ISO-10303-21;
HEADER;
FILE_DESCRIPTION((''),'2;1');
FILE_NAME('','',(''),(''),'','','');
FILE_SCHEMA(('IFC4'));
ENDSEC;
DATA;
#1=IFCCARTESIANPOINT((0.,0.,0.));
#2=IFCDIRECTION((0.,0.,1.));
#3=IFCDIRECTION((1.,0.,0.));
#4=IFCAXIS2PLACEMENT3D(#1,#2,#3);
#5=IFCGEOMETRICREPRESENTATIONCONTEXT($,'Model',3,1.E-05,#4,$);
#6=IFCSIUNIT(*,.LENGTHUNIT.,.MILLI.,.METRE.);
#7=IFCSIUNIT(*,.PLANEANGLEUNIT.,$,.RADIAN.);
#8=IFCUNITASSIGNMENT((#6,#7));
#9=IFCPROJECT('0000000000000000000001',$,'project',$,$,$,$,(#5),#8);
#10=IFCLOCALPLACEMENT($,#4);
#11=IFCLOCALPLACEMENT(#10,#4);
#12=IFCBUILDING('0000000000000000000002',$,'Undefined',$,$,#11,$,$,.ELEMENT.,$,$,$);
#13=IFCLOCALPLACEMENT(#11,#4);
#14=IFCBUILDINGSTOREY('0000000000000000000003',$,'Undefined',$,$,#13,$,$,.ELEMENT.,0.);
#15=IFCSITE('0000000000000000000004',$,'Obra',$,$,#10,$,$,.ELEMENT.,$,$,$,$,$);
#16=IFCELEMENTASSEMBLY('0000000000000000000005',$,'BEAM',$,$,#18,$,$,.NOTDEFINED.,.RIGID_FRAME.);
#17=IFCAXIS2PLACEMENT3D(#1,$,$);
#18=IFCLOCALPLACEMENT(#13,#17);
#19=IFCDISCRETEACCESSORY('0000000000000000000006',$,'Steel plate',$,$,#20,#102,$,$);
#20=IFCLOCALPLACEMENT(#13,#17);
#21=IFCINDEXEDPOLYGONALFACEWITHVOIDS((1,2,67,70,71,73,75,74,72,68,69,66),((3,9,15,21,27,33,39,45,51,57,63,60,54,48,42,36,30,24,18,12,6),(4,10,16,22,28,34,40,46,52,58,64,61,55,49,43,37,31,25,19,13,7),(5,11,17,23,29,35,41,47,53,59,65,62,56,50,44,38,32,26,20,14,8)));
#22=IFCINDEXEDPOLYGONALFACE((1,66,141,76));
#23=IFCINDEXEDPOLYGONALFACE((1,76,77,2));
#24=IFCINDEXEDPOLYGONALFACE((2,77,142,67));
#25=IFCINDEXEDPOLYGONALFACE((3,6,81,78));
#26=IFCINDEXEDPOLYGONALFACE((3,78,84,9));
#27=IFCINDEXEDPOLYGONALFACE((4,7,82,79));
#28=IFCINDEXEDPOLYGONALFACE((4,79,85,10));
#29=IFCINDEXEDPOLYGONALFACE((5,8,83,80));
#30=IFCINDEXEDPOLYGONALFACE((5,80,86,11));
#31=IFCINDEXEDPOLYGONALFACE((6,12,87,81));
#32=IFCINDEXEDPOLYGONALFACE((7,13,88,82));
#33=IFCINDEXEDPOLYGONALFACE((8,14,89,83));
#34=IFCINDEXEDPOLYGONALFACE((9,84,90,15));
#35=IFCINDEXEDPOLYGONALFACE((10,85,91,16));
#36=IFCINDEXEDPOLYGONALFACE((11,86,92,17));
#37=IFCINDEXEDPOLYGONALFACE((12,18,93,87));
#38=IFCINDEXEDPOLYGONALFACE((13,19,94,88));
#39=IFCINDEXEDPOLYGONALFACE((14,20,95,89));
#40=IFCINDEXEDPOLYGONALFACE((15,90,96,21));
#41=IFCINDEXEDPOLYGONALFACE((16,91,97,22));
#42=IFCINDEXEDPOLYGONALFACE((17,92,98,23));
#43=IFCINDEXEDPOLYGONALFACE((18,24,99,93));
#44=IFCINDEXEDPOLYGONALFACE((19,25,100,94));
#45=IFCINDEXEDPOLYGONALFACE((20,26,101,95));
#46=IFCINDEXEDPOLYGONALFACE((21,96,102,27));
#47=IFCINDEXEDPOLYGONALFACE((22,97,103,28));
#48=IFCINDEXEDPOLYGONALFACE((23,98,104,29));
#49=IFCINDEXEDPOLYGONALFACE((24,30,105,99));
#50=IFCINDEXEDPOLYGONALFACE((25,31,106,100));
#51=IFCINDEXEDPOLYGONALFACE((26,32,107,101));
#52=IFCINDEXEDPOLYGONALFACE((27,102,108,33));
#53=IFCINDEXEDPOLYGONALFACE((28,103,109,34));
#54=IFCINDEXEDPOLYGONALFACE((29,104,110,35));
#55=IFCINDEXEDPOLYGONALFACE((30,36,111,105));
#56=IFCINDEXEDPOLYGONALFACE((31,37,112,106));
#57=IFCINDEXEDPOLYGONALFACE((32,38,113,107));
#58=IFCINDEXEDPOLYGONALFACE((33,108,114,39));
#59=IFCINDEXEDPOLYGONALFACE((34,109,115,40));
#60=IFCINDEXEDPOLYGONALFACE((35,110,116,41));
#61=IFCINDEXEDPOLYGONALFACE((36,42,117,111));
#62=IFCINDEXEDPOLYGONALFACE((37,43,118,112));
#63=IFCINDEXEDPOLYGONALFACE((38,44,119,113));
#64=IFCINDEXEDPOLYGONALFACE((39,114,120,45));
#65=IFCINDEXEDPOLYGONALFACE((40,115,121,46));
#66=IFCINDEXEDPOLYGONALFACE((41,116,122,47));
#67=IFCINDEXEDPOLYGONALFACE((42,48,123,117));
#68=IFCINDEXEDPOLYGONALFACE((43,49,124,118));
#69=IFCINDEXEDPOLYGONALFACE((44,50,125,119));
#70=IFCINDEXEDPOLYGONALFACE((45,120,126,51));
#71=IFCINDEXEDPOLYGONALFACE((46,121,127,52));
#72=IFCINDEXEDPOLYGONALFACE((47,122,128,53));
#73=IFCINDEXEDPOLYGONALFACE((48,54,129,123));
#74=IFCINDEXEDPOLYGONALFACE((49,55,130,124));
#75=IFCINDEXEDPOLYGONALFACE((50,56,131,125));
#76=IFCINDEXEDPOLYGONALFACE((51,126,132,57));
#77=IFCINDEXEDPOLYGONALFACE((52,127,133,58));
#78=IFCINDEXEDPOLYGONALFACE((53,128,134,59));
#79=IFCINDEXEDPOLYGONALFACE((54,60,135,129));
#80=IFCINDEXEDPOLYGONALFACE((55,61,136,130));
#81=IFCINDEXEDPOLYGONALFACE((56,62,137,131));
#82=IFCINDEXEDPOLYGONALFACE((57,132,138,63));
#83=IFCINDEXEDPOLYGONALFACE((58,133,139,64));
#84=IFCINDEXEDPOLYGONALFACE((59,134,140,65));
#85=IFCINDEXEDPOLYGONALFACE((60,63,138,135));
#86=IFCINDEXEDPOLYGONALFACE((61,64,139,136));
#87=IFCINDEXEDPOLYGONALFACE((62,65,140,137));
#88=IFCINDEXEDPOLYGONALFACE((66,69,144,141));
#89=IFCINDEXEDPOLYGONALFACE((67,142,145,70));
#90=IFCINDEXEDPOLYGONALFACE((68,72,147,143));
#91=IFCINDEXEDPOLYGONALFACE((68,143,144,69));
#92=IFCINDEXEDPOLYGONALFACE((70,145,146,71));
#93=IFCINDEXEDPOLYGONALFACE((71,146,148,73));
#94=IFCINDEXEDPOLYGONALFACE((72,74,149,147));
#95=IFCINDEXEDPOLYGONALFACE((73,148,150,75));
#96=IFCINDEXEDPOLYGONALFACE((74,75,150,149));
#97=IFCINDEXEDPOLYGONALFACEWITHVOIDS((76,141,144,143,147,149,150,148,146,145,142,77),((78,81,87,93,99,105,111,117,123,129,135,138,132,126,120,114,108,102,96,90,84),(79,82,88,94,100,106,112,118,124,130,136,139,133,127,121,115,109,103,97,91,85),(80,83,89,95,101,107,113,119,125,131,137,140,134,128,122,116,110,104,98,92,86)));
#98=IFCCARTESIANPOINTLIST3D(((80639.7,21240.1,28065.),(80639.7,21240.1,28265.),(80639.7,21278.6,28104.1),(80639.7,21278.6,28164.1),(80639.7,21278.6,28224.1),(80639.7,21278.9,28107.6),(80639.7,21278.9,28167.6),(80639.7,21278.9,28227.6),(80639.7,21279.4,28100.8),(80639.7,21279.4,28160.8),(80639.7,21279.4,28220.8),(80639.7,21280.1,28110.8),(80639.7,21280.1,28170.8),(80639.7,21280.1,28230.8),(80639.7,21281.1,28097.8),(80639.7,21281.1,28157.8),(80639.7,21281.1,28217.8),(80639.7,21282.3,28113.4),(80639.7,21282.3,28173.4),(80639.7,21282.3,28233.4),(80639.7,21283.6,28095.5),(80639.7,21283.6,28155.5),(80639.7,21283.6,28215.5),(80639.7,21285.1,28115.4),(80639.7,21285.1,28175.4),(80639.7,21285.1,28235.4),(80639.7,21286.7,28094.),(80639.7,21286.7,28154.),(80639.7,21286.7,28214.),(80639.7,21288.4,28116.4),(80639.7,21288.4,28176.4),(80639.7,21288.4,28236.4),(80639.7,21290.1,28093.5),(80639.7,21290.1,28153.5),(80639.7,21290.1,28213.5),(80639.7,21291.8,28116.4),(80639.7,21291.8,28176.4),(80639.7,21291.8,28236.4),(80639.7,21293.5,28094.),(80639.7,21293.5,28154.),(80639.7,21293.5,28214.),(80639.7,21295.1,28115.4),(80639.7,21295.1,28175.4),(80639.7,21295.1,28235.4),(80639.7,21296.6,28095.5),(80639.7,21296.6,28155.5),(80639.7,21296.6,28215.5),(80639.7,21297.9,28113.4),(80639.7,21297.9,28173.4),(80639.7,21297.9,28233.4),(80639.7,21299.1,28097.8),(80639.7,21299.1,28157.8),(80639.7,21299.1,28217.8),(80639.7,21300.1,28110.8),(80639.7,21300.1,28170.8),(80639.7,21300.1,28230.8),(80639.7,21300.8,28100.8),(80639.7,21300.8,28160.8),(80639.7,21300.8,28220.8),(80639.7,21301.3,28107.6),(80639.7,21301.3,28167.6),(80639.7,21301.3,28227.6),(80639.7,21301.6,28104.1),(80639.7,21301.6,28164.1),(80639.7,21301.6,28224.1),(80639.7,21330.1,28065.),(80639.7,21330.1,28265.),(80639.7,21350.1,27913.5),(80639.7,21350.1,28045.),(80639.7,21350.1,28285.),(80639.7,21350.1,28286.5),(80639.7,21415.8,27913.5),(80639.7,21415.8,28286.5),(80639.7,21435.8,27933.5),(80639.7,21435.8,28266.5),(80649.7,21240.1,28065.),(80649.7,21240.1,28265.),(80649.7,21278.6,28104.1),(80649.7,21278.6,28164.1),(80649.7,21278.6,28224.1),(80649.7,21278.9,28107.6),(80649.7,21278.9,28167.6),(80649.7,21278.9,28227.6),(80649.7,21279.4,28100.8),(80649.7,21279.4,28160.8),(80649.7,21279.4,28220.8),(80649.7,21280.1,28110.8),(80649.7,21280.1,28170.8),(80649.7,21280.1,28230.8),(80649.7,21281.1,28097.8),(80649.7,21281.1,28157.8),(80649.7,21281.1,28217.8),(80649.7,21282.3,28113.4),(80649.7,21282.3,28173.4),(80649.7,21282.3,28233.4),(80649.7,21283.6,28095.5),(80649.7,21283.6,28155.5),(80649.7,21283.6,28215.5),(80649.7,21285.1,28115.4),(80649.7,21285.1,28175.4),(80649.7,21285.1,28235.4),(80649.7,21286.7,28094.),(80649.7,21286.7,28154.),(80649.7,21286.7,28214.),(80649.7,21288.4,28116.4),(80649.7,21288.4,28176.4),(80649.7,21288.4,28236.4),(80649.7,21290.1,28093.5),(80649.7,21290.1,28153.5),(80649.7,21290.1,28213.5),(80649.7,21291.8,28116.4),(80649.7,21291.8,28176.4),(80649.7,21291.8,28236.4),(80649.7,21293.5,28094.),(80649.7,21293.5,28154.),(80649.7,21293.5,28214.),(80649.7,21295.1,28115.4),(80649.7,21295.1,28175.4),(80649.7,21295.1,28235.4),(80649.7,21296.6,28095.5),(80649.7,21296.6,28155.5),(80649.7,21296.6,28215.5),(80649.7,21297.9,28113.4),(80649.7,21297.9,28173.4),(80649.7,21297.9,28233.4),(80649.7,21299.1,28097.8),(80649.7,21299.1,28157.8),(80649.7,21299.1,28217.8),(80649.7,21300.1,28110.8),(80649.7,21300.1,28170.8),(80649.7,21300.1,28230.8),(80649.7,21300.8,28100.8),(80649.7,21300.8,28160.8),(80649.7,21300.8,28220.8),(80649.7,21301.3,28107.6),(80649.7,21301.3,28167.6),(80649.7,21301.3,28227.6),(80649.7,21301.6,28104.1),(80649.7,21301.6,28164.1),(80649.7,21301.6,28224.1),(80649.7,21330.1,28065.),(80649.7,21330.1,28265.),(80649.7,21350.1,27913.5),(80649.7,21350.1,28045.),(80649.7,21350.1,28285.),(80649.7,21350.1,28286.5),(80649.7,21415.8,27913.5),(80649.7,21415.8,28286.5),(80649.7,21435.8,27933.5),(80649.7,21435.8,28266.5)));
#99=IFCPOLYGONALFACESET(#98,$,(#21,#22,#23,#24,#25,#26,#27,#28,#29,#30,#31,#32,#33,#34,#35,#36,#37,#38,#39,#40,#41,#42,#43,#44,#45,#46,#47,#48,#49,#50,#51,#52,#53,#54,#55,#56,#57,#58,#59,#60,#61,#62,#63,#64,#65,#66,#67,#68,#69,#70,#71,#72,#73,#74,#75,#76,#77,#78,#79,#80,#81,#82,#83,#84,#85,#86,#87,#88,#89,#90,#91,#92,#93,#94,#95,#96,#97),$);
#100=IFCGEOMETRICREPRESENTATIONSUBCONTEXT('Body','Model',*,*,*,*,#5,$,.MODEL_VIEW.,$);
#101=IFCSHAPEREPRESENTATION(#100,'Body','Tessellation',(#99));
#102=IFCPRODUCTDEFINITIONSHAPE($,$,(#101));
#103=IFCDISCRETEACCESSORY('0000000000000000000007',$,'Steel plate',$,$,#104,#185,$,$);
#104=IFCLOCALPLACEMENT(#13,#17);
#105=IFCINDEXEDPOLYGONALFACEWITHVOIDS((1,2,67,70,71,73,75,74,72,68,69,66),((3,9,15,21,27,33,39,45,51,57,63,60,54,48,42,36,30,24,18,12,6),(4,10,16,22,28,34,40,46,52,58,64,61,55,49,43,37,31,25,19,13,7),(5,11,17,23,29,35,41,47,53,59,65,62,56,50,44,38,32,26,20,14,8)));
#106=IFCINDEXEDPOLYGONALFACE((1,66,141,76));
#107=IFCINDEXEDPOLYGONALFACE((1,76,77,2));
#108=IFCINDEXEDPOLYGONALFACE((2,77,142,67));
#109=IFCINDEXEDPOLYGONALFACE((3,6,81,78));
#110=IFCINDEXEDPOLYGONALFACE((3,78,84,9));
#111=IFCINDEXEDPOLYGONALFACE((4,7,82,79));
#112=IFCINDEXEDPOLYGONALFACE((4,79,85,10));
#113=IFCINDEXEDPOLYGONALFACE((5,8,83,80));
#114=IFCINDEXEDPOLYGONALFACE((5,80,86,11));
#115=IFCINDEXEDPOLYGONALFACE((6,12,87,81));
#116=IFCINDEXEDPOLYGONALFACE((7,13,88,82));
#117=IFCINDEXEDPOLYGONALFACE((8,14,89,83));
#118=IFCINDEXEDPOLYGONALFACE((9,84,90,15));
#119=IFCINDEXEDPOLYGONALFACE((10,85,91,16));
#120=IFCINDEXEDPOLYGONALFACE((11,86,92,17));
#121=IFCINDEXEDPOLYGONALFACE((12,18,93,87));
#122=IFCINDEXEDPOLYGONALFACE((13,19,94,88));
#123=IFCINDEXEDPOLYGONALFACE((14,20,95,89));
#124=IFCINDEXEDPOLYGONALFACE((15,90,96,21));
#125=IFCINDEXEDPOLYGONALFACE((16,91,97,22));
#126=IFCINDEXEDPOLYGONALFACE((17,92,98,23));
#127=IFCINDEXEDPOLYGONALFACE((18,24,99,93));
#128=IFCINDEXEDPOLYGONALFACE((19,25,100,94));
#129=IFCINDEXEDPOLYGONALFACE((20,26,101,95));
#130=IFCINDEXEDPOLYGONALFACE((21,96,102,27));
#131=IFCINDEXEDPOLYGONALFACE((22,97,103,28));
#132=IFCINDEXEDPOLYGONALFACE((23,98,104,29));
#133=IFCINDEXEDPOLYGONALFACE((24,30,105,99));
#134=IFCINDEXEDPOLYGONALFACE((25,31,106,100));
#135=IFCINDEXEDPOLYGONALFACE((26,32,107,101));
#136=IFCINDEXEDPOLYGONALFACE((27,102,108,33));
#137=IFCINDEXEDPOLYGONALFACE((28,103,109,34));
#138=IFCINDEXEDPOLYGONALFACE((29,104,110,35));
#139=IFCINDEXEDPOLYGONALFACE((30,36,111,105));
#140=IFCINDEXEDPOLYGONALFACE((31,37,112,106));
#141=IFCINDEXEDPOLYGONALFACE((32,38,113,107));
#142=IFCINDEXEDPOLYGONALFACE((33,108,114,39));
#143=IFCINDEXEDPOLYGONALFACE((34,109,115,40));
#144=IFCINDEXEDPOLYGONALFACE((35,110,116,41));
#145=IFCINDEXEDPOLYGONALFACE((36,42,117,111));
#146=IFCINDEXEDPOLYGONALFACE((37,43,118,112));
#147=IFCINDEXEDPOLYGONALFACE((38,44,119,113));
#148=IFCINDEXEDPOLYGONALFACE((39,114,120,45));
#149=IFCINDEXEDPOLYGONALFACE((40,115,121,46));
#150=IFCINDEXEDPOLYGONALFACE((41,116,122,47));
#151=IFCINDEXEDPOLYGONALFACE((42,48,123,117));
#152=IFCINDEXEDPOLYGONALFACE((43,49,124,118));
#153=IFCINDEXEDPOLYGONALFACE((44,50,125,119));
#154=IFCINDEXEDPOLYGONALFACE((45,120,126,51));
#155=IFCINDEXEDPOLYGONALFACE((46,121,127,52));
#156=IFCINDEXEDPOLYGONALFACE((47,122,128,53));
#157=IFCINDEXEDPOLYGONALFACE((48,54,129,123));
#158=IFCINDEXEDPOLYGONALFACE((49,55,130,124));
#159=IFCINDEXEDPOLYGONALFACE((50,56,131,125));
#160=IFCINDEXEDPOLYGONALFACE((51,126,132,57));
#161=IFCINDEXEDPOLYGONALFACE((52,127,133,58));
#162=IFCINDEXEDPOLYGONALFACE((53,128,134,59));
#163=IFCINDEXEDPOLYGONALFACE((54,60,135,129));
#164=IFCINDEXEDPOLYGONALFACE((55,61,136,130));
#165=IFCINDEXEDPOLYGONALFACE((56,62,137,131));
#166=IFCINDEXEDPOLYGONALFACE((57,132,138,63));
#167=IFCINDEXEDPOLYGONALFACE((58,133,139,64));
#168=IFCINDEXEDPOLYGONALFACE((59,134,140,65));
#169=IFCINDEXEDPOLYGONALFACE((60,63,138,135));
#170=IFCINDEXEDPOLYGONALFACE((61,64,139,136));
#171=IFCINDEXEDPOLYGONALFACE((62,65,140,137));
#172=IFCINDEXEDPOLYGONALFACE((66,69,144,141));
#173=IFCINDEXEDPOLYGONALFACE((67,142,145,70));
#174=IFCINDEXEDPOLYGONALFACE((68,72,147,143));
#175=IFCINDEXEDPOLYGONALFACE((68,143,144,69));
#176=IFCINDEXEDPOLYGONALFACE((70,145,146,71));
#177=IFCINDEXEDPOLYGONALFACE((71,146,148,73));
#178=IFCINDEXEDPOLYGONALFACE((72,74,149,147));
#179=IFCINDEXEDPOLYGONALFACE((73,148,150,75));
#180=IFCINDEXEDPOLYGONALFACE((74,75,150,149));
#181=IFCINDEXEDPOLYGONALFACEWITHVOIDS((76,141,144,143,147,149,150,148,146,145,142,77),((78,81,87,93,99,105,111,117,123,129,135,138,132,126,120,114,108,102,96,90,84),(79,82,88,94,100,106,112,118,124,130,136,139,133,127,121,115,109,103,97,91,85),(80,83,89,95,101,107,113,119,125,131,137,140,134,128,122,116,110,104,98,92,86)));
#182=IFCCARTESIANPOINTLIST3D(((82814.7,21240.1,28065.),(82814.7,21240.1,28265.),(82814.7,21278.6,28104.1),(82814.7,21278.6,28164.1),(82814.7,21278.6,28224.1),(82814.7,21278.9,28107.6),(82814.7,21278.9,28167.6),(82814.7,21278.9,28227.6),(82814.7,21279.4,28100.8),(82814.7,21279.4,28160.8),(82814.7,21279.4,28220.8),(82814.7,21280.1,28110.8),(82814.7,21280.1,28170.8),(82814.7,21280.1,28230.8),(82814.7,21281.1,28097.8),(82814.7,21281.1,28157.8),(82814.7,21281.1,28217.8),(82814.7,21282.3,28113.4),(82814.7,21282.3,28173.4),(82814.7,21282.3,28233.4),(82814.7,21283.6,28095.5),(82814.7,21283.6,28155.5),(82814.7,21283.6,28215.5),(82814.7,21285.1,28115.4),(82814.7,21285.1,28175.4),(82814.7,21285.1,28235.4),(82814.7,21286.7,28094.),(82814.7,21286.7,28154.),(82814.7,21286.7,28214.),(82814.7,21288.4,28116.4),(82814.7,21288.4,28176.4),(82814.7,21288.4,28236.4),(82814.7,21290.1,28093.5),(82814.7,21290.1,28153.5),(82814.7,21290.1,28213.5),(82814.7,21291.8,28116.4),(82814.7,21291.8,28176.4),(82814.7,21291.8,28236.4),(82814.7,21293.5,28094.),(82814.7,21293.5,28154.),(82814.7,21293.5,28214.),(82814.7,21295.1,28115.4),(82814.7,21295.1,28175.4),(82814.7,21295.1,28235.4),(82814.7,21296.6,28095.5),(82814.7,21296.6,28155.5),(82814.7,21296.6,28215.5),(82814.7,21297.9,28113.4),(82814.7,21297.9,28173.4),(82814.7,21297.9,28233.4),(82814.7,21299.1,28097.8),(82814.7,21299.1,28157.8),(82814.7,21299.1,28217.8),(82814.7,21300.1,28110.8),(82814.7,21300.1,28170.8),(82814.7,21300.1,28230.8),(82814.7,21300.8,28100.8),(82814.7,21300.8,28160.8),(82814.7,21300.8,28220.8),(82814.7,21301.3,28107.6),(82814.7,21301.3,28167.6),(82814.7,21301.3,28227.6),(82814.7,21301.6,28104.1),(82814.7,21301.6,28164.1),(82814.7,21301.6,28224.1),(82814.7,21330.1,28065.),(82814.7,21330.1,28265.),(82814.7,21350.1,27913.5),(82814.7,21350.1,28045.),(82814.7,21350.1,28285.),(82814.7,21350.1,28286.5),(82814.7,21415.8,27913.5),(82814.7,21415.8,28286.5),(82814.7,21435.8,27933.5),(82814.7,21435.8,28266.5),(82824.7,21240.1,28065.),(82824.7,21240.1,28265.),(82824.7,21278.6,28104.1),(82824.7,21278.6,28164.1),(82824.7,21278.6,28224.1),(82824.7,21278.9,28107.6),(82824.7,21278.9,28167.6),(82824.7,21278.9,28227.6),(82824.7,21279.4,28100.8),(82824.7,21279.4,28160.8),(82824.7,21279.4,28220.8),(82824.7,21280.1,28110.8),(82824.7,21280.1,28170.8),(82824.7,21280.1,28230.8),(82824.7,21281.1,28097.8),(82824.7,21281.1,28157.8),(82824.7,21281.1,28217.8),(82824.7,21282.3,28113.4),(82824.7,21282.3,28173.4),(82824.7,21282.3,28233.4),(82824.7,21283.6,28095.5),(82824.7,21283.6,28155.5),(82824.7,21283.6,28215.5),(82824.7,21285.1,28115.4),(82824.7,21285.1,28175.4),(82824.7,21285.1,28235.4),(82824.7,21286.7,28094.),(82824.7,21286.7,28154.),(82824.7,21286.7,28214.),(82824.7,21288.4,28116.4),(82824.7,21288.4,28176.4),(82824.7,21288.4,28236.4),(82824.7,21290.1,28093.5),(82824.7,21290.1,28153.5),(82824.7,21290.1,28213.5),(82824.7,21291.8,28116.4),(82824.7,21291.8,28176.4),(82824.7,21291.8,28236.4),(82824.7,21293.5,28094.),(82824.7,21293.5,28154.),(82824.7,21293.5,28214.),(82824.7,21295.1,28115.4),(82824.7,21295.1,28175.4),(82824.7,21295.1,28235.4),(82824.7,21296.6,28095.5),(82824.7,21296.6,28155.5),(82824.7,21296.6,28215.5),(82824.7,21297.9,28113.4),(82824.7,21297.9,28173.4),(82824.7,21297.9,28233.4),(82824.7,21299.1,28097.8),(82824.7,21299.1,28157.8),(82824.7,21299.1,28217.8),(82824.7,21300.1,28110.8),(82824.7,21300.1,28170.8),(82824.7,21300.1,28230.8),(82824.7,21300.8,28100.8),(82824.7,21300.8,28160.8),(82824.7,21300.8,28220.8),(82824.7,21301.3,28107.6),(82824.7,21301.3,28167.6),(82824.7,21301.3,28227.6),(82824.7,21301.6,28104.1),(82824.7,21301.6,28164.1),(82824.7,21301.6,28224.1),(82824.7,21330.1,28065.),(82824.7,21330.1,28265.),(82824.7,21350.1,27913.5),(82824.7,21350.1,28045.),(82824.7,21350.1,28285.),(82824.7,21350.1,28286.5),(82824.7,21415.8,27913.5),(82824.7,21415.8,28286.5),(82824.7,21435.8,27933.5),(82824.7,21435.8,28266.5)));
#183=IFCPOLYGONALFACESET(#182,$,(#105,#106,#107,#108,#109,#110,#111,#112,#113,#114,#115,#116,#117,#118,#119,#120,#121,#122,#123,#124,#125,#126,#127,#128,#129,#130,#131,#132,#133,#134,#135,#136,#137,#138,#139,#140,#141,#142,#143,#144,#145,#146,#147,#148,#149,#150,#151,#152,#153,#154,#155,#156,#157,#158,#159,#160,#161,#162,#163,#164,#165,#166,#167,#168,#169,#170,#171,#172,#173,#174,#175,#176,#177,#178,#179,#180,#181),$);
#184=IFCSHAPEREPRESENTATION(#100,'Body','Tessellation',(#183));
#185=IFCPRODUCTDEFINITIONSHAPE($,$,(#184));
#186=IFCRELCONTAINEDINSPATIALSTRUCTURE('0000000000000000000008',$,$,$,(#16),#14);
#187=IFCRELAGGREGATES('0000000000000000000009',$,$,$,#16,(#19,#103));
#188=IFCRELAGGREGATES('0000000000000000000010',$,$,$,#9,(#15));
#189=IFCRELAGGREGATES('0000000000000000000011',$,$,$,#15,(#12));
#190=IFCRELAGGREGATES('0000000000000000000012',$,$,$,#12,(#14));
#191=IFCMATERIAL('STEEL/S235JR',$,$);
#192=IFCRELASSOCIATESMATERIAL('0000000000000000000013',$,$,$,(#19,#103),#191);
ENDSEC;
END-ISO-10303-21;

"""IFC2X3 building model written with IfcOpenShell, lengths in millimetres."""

from ifc_helpers import new_model, si_unit, frame, origin_with_axes, origin_2d_with_axis, place, context, subcontext, project, spatial, polyline, circle, outline, extrude, source, transform, mapped, material, element, aggregate, save


model = new_model("IFC2X3")

# Units and contexts
model_context = context("Model", 3, precision=1e-05, world=origin_with_axes())
body_context = subcontext(model_context, "Body", "Model", "MODEL_VIEW")
ifc_project = project(units=[si_unit("LENGTHUNIT", "METRE", prefix="MILLI"), si_unit("PLANEANGLEUNIT", "RADIAN")], contexts=[model_context])

# Site, building, storey
site_placement = place(None, origin_with_axes())
site = spatial("IfcSite", under=ifc_project, at=site_placement, Name="Obra", CompositionType="ELEMENT")
building_placement = place(site_placement, origin_with_axes())
building = spatial("IfcBuilding", under=site, at=building_placement, Name="Undefined", CompositionType="ELEMENT")
storey_placement = place(building_placement, origin_with_axes())
storey = spatial("IfcBuildingStorey", under=building, at=storey_placement, Name="Undefined", CompositionType="ELEMENT", Elevation=0.0)

# Shared definitions
ifc_material = material(Name="STEEL/S235JR")

# Element assembly, discrete accessories, openings
assembly_1_placement = place(storey_placement, origin_with_axes())
assembly_1 = element("IfcElementAssembly", 1, at=assembly_1_placement, inside=storey, Name="BEAM", AssemblyPlace="NOTDEFINED", PredefinedType="RIGID_FRAME")
discrete_accessory_1_placement = place(assembly_1_placement, frame((80644.7, 21435.8, 27933.5), z_axis=(-1.0, 0.0, 0.0), x_axis=(0.000001, -0.707107, -0.707107)))
discrete_accessory_1 = element("IfcDiscreteAccessory", 2, at=discrete_accessory_1_placement, material=ifc_material, Name="Steel plate", context=body_context, shape_type="SweptSolid", body=[
    extrude(outline(polyline([(0.0, 0.0), (28.3, 0.0), (74.7, 46.5), (-18.2, 139.4), (-18.2, 167.7), (45.4, 231.4), (-96.0, 372.8), (-159.7, 309.1), (-187.9, 309.1), (-189.0, 310.2), (-235.5, 263.8), (-235.5, 235.5), (0.0, 0.0)])), frame((0.0, 0.0, -5.0), z_axis=(0.0, 0.0, 1.0), x_axis=(1.0, 0.0, 0.0)), (0.0, 0.0, 1.0), 10.0),
])
shared_shape_1 = source(origin_with_axes(), body_context, "Body", "SweptSolid", [
    extrude(circle(Radius=11.5, at=origin_2d_with_axis()), frame((0.0, -13.4, 0.0), z_axis=(0.0, 1.0, 0.0), x_axis=(1.0, 0.0, 0.0)), (0.0, 0.0, 1.0), 10.2),
])
opening_1_placement = place(assembly_1_placement, frame((80653.0, 21340.1, 28265.0), z_axis=(0.0, -1.0, 0.0), x_axis=(0.0, 0.0, -1.0)))
element("IfcOpeningElement", 3, at=opening_1_placement, cuts=discrete_accessory_1, ObjectType="Opening", context=body_context, shape_type="MappedRepresentation", body=[
    mapped(shared_shape_1, transform((40.0, 0.0, 50.0))),
    mapped(shared_shape_1, transform((100.0, 0.0, 50.0))),
    mapped(shared_shape_1, transform((160.0, 0.0, 50.0))),
])
discrete_accessory_2_placement = place(assembly_1_placement, frame((82819.7, 21435.8, 27933.5), z_axis=(-1.0, 0.0, 0.0), x_axis=(0.000001, -0.707107, -0.707107)))
discrete_accessory_2 = element("IfcDiscreteAccessory", 4, at=discrete_accessory_2_placement, material=ifc_material, Name="Steel plate", context=body_context, shape_type="SweptSolid", body=[
    extrude(outline(polyline([(0.0, 0.0), (28.3, 0.0), (74.7, 46.5), (-18.2, 139.4), (-18.2, 167.7), (45.4, 231.4), (-96.0, 372.8), (-159.7, 309.1), (-187.9, 309.1), (-189.0, 310.2), (-235.5, 263.8), (-235.5, 235.5), (0.0, 0.0)])), frame((0.0, 0.0, -5.0), z_axis=(0.0, 0.0, 1.0), x_axis=(1.0, 0.0, 0.0)), (0.0, 0.0, 1.0), 10.0),
])
opening_2_placement = place(assembly_1_placement, frame((82828.0, 21340.1, 28265.0), z_axis=(0.0, -1.0, 0.0), x_axis=(0.0, 0.0, -1.0)))
element("IfcOpeningElement", 5, at=opening_2_placement, cuts=discrete_accessory_2, ObjectType="Opening", context=body_context, shape_type="MappedRepresentation", body=[
    mapped(shared_shape_1, transform((40.0, 0.0, 50.0))),
    mapped(shared_shape_1, transform((100.0, 0.0, 50.0))),
    mapped(shared_shape_1, transform((160.0, 0.0, 50.0))),
])
aggregate(assembly_1, [discrete_accessory_1, discrete_accessory_2])

save(model, "model.ifc")
